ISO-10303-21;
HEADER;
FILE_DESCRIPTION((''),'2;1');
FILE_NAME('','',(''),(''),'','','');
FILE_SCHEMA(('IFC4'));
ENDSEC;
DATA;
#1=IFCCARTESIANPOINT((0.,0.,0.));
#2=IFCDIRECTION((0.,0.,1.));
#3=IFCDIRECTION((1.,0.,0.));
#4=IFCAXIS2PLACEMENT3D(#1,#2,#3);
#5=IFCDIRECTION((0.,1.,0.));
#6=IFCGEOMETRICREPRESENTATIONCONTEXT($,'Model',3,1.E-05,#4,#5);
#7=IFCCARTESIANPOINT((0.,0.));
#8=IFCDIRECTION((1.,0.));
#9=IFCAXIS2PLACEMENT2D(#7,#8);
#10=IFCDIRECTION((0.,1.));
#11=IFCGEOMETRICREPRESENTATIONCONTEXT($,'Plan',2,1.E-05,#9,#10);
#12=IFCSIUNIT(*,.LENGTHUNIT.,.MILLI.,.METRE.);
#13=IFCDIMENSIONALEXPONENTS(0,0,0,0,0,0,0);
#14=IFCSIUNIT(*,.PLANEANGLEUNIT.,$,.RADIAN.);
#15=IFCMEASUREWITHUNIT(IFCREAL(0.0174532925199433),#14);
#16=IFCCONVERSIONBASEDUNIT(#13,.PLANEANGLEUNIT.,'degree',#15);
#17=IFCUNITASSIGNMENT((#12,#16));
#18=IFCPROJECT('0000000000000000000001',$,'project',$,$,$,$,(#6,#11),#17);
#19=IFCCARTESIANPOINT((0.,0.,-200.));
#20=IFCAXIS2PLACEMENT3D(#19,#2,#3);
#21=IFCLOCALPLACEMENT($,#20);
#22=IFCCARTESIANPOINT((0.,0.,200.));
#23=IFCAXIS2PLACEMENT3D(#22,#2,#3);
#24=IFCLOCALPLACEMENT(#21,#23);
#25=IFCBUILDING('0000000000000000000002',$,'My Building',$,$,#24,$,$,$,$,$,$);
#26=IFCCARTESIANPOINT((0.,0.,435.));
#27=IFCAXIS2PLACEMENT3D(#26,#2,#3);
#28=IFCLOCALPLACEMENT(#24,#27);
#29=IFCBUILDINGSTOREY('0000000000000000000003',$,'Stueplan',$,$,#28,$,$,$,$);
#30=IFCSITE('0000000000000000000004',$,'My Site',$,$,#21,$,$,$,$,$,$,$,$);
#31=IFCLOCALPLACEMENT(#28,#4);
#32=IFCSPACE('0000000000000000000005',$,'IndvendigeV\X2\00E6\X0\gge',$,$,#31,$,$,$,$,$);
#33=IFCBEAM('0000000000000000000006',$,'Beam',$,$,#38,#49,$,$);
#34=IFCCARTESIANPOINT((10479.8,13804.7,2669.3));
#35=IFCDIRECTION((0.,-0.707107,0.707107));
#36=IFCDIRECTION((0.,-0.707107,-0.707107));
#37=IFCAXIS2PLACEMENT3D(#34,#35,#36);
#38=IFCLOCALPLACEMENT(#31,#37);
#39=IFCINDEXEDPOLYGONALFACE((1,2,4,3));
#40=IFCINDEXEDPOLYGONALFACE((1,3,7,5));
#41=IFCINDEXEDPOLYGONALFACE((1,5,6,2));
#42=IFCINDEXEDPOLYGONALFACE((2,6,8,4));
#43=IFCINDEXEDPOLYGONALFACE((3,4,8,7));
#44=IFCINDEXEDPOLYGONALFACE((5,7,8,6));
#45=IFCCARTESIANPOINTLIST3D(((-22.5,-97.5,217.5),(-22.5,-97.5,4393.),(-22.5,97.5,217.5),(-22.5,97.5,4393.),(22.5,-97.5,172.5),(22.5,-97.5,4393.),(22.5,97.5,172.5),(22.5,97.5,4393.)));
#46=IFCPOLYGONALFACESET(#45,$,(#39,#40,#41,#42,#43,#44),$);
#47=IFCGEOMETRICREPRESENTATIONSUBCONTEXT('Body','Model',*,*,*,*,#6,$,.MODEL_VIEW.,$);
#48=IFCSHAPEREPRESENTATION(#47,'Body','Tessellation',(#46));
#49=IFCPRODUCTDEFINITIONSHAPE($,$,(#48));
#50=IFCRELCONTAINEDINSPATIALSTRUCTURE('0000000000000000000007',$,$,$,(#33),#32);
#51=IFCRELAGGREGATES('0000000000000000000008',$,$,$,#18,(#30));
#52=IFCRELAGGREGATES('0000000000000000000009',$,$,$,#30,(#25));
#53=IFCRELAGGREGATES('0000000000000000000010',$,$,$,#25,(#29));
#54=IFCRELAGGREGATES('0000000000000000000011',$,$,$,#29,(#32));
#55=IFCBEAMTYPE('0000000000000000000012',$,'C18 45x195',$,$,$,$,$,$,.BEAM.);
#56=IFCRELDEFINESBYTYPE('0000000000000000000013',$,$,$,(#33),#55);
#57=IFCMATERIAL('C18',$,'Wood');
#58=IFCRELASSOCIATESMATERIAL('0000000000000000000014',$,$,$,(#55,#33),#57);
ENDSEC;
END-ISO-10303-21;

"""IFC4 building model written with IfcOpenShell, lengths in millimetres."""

from ifc_helpers import new_model, entity, si_unit, converted_unit, direction, frame, origin_with_axes, origin_2d_with_axis, place, context, subcontext, project, spatial, rectangle, extrude, clip, halfspace, material, material_profile, profile_set, profile_usage, type_object, element, save


model = new_model("IFC4")

# Units and contexts
model_context = context("Model", 3, precision=1e-05, world=origin_with_axes(), true_north=direction((0.0, 1.0, 0.0)))
plan_context = context("Plan", 2, precision=1e-05, world=origin_2d_with_axis(), true_north=direction((0.0, 1.0)))
body_context_1 = subcontext(model_context, "Body", "Model", "MODEL_VIEW")
ifc_project = project(units=[si_unit("LENGTHUNIT", "METRE", prefix="MILLI"), converted_unit("PLANEANGLEUNIT", "degree", entity("IfcReal", 0.0174532925199433), si_unit("PLANEANGLEUNIT", "RADIAN"), dimensions=[0, 0, 0, 0, 0, 0, 0])], contexts=[model_context, plan_context])

# Site, building, storey
site_placement = place(None, frame((0.0, 0.0, -200.0), z_axis=(0.0, 0.0, 1.0), x_axis=(1.0, 0.0, 0.0)))
site = spatial("IfcSite", under=ifc_project, at=site_placement, Name="My Site")
building_placement = place(site_placement, frame((0.0, 0.0, 200.0), z_axis=(0.0, 0.0, 1.0), x_axis=(1.0, 0.0, 0.0)))
building = spatial("IfcBuilding", under=site, at=building_placement, Name="My Building")
storey_placement = place(building_placement, frame((0.0, 0.0, 435.0), z_axis=(0.0, 0.0, 1.0), x_axis=(1.0, 0.0, 0.0)))
storey = spatial("IfcBuildingStorey", under=building, at=storey_placement, Name="Stueplan")

# Shared definitions
ifc_material = material(Name="C18", Category="Wood")

# Shared definitions
space_1_placement = place(storey_placement, frame((0.0, 0.0, 0.0), z_axis=(0.0, 0.0, 1.0), x_axis=(1.0, 0.0, 0.0)))
space_1 = spatial("IfcSpace", under=storey, at=space_1_placement, Name="IndvendigeVægge")

# Beam
ifc_material_profile_1 = material_profile(ifc_material, rectangle(XDim=45.0, YDim=195.0))
ifc_profile_set_1 = profile_set([ifc_material_profile_1], Name="woodStructural")
beam_type_1 = type_object("IfcBeamType", Name="C18 45x195", PredefinedType="BEAM", material=ifc_profile_set_1)
ifc_profile_usage_1 = profile_usage(ifc_profile_set_1)
beam_1_placement = place(space_1_placement, frame((10479.8, 13804.7, 2669.3), z_axis=(0.0, -0.707107, 0.707107), x_axis=(0.0, -0.707107, -0.707107)))
element("IfcBeam", 1, at=beam_1_placement, inside=space_1, type_object=beam_type_1, material=ifc_profile_usage_1, Name="Beam", context=body_context_1, shape_type="Clipping", body=[
    clip(extrude(rectangle(XDim=45.0, YDim=195.0), origin_with_axes(), (0.0, 0.0, 1.0), 4393.0), halfspace(frame((1953.2, 0.0, -1758.2), z_axis=(-0.707107, 0.0, -0.707107), x_axis=(0.0, 1.0, 0.0)), False)),
])

save(model, "model.ifc")
